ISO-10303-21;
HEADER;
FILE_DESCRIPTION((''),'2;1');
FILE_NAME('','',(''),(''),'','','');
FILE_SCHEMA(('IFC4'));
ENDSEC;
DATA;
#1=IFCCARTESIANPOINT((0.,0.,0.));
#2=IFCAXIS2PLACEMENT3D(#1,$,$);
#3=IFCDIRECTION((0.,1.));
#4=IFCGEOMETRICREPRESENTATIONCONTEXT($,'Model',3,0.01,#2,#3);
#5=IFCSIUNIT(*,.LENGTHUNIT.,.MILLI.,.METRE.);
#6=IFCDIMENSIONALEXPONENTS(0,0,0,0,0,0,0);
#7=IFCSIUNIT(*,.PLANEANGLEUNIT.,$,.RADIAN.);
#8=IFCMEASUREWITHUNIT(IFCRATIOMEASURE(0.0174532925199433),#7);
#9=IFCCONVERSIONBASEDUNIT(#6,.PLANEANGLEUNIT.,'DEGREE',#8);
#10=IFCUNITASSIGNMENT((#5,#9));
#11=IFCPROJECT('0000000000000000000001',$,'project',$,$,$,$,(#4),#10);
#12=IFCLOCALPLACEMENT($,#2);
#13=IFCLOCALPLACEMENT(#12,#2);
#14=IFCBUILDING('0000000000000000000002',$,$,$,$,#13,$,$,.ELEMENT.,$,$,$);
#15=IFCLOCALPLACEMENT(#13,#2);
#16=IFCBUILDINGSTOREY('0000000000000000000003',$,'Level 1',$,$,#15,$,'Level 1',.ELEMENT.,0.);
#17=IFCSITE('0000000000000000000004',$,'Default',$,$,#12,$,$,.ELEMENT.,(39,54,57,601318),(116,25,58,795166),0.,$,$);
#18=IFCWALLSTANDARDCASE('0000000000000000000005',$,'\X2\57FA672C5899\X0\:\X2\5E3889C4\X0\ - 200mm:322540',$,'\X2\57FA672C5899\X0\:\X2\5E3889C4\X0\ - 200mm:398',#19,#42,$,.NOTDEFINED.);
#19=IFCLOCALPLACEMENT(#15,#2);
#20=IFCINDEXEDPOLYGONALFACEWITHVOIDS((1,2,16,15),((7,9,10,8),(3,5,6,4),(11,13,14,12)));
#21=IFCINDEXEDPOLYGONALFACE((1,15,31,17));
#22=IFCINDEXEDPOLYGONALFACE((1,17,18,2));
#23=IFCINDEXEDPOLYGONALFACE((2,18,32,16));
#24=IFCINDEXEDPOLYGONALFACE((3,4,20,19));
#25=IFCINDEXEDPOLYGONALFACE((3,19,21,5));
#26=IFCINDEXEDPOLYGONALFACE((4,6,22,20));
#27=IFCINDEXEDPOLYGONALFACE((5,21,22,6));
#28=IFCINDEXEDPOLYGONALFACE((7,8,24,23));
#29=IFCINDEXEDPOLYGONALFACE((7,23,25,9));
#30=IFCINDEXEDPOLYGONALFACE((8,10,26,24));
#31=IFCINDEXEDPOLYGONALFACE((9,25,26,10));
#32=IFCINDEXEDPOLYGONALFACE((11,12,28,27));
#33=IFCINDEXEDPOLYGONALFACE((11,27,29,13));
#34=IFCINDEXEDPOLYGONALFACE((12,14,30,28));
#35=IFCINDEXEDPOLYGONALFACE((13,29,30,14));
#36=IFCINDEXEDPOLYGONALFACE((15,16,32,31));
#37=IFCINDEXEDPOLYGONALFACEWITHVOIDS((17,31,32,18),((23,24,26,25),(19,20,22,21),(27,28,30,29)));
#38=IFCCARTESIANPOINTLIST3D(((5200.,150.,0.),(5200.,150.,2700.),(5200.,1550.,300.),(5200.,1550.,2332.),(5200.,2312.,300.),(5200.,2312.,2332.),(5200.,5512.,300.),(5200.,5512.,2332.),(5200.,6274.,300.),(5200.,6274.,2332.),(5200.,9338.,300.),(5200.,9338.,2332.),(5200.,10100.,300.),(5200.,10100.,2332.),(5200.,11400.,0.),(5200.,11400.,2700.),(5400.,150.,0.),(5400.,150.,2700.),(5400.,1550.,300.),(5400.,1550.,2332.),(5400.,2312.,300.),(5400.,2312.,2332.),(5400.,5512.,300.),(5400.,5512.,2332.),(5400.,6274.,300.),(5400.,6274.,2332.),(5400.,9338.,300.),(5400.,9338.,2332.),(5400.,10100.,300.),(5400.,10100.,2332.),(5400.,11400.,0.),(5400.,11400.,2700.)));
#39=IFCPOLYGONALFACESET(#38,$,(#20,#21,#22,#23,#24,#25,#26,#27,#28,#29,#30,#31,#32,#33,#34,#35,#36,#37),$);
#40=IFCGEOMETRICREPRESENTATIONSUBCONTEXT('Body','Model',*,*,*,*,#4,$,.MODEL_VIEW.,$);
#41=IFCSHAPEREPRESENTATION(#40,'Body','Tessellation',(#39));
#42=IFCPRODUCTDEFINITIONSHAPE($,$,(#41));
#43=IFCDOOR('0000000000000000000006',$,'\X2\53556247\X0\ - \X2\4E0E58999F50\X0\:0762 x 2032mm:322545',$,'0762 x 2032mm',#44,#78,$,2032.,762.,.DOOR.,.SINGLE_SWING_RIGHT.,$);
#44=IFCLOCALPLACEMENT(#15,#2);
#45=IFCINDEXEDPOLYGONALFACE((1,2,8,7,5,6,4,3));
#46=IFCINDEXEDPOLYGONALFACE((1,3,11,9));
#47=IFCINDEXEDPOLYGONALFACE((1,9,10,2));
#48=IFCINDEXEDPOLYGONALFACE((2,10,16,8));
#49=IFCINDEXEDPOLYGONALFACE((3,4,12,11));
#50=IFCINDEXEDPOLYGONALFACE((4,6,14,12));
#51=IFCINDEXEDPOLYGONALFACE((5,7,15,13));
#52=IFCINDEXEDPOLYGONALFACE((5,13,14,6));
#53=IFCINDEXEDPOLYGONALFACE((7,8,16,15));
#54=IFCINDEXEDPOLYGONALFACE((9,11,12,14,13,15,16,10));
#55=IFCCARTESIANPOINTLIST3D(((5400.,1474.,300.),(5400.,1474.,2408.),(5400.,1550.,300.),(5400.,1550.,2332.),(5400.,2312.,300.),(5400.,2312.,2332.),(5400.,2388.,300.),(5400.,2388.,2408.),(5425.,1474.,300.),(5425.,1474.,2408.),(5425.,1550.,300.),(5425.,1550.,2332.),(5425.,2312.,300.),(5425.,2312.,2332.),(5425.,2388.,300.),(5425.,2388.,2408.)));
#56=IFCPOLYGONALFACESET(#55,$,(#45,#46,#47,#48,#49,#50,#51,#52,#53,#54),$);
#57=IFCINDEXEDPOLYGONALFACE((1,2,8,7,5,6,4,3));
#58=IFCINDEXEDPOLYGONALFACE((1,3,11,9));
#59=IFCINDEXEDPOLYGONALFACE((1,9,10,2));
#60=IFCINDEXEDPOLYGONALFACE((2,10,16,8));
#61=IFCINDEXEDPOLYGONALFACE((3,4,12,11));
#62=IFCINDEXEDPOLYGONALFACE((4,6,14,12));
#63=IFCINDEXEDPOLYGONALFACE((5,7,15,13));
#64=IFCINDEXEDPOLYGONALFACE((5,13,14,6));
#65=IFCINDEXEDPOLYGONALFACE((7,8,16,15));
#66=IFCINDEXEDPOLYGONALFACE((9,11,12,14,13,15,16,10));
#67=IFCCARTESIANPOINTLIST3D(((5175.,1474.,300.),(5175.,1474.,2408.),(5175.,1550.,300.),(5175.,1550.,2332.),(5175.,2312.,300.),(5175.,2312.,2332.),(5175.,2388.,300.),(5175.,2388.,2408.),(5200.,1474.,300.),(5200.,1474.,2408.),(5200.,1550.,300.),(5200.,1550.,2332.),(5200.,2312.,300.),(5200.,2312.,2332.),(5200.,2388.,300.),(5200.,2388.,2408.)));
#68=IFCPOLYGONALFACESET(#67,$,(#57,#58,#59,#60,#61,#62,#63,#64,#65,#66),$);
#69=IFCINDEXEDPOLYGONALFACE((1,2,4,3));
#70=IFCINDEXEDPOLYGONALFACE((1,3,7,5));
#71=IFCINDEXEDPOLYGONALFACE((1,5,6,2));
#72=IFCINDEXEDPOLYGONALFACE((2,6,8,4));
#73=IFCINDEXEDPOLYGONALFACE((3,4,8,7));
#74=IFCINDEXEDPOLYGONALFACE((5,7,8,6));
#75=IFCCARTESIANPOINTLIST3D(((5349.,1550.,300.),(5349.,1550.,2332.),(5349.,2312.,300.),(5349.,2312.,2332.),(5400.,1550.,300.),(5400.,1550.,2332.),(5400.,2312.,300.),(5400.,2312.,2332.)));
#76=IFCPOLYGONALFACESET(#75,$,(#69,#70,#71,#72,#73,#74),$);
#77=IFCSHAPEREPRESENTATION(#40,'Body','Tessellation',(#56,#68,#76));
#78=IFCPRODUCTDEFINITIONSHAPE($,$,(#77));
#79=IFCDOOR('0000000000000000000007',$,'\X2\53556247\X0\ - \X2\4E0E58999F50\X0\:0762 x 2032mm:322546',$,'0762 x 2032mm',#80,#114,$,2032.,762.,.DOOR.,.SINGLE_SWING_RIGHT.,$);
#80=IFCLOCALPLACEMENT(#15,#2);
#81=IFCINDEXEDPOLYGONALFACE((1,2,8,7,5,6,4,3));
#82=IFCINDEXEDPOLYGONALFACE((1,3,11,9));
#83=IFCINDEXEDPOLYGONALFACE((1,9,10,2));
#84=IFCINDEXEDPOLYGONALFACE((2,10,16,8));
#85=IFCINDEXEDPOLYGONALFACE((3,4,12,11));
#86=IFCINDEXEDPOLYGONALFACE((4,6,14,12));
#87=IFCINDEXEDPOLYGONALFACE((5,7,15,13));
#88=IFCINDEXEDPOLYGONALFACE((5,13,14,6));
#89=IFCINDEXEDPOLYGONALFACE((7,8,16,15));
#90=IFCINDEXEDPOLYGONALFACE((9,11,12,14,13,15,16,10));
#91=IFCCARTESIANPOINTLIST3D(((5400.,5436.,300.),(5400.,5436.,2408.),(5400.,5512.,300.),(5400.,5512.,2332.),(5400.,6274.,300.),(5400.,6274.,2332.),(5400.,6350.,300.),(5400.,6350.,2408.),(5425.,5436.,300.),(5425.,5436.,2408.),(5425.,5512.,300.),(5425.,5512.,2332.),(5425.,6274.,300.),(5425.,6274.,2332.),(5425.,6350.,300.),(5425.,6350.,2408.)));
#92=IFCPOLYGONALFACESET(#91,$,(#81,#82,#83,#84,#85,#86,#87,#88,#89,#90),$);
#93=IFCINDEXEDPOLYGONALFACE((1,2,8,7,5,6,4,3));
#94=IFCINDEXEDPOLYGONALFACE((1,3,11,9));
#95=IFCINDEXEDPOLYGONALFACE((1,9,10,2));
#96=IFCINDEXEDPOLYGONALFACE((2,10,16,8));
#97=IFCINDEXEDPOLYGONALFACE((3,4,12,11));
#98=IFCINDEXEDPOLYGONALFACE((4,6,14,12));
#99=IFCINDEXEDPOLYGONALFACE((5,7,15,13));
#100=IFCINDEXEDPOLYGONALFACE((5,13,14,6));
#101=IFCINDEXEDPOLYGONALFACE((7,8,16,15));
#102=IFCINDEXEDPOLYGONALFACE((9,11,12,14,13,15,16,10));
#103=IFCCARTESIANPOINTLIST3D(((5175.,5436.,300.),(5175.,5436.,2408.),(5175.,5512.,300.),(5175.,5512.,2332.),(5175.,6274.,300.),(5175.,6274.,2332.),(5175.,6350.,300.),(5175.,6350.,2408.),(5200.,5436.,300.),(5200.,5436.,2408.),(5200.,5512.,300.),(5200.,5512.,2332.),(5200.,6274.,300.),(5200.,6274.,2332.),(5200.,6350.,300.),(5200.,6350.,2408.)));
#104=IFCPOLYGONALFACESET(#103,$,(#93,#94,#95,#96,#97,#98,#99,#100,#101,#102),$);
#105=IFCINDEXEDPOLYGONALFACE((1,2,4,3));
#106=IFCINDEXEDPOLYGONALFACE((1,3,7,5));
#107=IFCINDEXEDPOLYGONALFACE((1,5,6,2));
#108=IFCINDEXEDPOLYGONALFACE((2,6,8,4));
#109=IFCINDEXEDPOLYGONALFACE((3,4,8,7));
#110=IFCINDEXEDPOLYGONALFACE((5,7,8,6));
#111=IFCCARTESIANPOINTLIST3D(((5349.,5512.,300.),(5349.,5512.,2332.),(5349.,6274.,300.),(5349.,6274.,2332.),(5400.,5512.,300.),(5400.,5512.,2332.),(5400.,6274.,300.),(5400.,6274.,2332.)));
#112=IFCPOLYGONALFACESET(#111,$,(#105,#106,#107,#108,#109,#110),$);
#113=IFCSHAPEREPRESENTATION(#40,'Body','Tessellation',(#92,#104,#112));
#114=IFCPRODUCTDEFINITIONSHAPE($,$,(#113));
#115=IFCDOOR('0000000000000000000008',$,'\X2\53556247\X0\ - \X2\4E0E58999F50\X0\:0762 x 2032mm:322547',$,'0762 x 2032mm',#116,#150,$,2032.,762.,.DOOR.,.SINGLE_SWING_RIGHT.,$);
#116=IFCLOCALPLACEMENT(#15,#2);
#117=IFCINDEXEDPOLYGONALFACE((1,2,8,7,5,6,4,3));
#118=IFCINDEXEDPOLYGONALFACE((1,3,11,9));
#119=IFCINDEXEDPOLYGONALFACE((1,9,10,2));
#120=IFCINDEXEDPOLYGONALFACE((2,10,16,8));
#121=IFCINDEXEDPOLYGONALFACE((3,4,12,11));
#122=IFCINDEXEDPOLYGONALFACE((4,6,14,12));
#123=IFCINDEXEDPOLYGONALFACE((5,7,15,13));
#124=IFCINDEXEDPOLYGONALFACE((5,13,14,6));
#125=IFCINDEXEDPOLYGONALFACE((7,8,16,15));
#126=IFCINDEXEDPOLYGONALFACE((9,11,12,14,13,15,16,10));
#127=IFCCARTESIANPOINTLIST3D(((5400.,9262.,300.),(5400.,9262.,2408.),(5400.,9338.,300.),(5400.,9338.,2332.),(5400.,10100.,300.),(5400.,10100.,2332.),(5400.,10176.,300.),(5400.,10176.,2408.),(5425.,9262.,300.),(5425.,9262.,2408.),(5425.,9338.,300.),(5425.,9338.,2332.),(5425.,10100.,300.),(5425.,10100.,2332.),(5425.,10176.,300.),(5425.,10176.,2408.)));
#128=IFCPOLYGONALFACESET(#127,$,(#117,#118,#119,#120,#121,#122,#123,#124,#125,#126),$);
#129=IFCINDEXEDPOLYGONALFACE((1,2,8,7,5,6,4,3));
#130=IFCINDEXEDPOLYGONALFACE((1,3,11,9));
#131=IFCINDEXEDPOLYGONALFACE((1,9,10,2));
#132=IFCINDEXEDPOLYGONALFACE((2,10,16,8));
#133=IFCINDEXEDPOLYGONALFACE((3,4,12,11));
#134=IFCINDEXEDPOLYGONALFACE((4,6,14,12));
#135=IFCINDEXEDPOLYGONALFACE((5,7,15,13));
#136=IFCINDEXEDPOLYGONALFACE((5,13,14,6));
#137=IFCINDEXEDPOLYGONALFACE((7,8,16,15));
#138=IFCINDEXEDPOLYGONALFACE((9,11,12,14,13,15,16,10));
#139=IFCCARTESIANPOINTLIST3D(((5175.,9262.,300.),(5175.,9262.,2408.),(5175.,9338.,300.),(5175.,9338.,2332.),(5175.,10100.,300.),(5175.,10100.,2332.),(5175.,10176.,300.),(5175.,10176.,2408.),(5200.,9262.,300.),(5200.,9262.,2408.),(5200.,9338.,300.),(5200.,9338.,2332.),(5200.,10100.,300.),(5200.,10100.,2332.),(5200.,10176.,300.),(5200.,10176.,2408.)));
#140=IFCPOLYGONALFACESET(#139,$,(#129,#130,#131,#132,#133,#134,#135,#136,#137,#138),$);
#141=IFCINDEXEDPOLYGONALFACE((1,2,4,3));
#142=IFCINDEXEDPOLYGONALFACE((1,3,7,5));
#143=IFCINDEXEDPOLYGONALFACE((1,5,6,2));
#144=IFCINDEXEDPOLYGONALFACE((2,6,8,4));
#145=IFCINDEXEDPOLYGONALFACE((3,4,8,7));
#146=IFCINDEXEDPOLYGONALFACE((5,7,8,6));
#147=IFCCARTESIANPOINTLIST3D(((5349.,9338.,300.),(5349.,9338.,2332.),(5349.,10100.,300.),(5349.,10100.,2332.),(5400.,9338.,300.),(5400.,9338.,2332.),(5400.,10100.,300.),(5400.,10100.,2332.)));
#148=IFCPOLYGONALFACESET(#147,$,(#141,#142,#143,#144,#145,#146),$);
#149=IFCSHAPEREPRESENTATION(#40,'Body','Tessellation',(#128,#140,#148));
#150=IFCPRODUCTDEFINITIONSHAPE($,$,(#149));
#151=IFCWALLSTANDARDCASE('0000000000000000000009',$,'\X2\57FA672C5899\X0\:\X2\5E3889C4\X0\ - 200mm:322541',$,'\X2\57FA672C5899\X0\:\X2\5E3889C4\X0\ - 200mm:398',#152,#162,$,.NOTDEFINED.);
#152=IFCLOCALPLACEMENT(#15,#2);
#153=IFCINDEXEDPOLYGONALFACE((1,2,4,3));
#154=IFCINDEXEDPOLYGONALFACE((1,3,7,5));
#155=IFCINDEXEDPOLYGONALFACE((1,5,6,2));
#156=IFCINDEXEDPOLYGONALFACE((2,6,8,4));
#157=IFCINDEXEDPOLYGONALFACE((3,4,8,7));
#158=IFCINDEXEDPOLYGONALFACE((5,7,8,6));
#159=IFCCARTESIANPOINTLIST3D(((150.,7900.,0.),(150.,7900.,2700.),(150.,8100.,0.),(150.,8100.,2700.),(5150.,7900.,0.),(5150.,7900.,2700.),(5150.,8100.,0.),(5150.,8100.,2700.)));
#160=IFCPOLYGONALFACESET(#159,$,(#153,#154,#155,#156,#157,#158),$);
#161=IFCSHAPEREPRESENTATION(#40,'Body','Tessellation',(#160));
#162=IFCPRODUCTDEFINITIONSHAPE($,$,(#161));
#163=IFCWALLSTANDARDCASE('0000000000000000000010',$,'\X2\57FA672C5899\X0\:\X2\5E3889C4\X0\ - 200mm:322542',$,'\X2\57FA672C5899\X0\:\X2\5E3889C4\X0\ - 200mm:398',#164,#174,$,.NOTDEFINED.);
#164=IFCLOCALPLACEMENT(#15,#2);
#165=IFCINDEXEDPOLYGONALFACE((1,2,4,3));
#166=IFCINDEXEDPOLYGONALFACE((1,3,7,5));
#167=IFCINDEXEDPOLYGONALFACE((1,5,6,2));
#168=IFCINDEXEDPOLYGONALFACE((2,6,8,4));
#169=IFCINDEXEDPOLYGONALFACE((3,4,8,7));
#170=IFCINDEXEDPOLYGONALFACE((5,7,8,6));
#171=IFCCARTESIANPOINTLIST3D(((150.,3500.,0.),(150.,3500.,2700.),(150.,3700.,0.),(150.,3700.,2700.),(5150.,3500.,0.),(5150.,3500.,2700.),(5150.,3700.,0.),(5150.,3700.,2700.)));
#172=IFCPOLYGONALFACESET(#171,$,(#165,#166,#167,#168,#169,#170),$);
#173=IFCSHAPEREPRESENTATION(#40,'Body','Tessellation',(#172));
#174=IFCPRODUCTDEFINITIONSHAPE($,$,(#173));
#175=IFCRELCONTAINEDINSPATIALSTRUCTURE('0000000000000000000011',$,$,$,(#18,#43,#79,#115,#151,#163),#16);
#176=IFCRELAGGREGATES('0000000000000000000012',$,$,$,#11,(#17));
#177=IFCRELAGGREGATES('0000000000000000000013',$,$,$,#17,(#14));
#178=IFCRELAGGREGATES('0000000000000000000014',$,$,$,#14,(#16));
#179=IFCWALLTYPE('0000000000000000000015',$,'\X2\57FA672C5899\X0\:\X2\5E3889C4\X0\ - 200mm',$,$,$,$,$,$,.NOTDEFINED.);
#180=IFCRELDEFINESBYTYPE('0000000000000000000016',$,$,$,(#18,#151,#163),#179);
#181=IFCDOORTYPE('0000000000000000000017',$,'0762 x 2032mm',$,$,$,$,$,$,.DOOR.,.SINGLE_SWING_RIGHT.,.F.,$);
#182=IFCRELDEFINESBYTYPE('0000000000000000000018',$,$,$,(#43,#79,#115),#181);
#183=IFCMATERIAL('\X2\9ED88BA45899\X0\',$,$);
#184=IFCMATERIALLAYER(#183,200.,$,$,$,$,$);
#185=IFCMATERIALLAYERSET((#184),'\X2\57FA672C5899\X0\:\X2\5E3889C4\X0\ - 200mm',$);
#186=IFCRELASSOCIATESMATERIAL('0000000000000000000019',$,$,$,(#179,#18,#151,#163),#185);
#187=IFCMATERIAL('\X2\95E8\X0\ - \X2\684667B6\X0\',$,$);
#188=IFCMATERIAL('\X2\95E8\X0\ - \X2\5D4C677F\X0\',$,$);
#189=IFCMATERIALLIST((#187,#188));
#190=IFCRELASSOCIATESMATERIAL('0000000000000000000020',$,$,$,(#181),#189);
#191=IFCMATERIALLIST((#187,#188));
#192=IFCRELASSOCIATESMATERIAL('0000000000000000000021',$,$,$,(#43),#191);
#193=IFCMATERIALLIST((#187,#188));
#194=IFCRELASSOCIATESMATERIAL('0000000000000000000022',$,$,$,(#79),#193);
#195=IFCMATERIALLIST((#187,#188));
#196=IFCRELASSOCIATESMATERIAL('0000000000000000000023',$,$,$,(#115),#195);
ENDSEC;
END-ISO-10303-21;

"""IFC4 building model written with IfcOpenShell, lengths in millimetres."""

from ifc_helpers import new_model, entity, si_unit, converted_unit, direction, frame, frame_2d, origin, place, context, subcontext, project, spatial, polyline, rectangle, outline, extrude, clip, bounded_halfspace, source, transform, mapped, material, material_list, layer, layer_set, layer_usage, type_object, type_shapes, element, fill, save


model = new_model("IFC4")

# Units and contexts
model_context_1 = context("Model", 3, precision=0.01, world=origin(), true_north=direction((0.0, 1.0)))
body_context_1 = subcontext(model_context_1, "Body", "Model", "MODEL_VIEW")
ifc_project = project(units=[si_unit("LENGTHUNIT", "METRE", prefix="MILLI"), converted_unit("PLANEANGLEUNIT", "DEGREE", entity("IfcRatioMeasure", 0.0174532925199433), si_unit("PLANEANGLEUNIT", "RADIAN"), dimensions=[0, 0, 0, 0, 0, 0, 0])], contexts=[model_context_1])

# Site, building, storey
site_placement = place(None, origin())
site = spatial("IfcSite", under=ifc_project, at=site_placement, Name="Default", CompositionType="ELEMENT", RefLatitude=(39, 54, 57, 601318), RefLongitude=(116, 25, 58, 795166), RefElevation=0.0)
building_placement = place(site_placement, origin())
building = spatial("IfcBuilding", under=site, at=building_placement, CompositionType="ELEMENT")
storey_placement = place(building_placement, origin())
storey = spatial("IfcBuildingStorey", under=building, at=storey_placement, Name="Level 1", LongName="Level 1", CompositionType="ELEMENT", Elevation=0.0)

# Shared definitions
ifc_material_1 = material(Name="默认墙")
ifc_layer_1 = layer(ifc_material_1, 200.0)
ifc_layer_set_1 = layer_set([ifc_layer_1], Name="基本墙:常规 - 200mm")
wall_type = type_object("IfcWallType", Name="基本墙:常规 - 200mm", PredefinedType="NOTDEFINED", material=ifc_layer_set_1)

# Wall, openings, doors
ifc_layer_usage_1 = layer_usage(ifc_layer_set_1, "AXIS2", "NEGATIVE", 100.0)
wall_1_placement = place(storey_placement, frame((5300.0, 11400.0, 0.0), z_axis=(0.0, 0.0, 1.0), x_axis=(0.0, -1.0, 0.0)))
wall_1 = element("IfcWallStandardCase", 1, at=wall_1_placement, inside=storey, type_object=wall_type, material=ifc_layer_usage_1, Name="基本墙:常规 - 200mm:322540", ObjectType="基本墙:常规 - 200mm:398", PredefinedType="NOTDEFINED", context=body_context_1, shape_type="Clipping", body=[
    clip(extrude(rectangle(XDim=11250.0, YDim=200.0, at=frame_2d((5625.0, 0.0), x_axis=(-1.0, 0.0))), origin(), (0.0, 0.0, 1.0), 2700.0), bounded_halfspace(frame((0.0, -100.0, 2700.0), z_axis=(0.0, 0.0, -1.0), x_axis=(-1.0, 0.0, 0.0)), True, frame((0.0, -100.0, 2700.0)), polyline([(0.0, 0.0), (11250.0, 0.0), (11250.0, 200.0), (0.0, 200.0), (0.0, 0.0)]))),
])
opening_1_placement = place(wall_1_placement, frame((9088.0, -100.0, 300.0)))
opening_1 = element("IfcOpeningElement", 2, at=opening_1_placement, cuts=wall_1, ObjectType="Opening", PredefinedType="OPENING", context=body_context_1, shape_type="SweptSolid", body=[
    extrude(rectangle(XDim=762.0, YDim=2032.0, at=frame_2d((1016.0, 381.0), x_axis=(0.0, 1.0))), frame((0.0, 0.0, 0.0), z_axis=(0.0, 1.0, 0.0), x_axis=(0.0, 0.0, 1.0)), (0.0, 0.0, 1.0), 200.0),
])
opening_2_placement = place(wall_1_placement, frame((5126.0, -100.0, 300.0)))
opening_2 = element("IfcOpeningElement", 3, at=opening_2_placement, cuts=wall_1, ObjectType="Opening", PredefinedType="OPENING", context=body_context_1, shape_type="SweptSolid", body=[
    extrude(rectangle(XDim=762.0, YDim=2032.0, at=frame_2d((1016.0, 381.0), x_axis=(0.0, 1.0))), frame((0.0, 0.0, 0.0), z_axis=(0.0, 1.0, 0.0), x_axis=(0.0, 0.0, 1.0)), (0.0, 0.0, 1.0), 200.0),
])
opening_3_placement = place(wall_1_placement, frame((1300.0, -100.0, 300.0)))
opening_3 = element("IfcOpeningElement", 4, at=opening_3_placement, cuts=wall_1, ObjectType="Opening", PredefinedType="OPENING", context=body_context_1, shape_type="SweptSolid", body=[
    extrude(rectangle(XDim=762.0, YDim=2032.0, at=frame_2d((1016.0, 381.0), x_axis=(0.0, 1.0))), frame((0.0, 0.0, 0.0), z_axis=(0.0, 1.0, 0.0), x_axis=(0.0, 0.0, 1.0)), (0.0, 0.0, 1.0), 200.0),
])
ifc_material_2 = material(Name="门 - 框架")
ifc_material_3 = material(Name="门 - 嵌板")
ifc_material_list_1 = material_list([ifc_material_2, ifc_material_3])
ifc_material_list_2 = material_list([ifc_material_2, ifc_material_3])
door_type = type_object("IfcDoorType", Name="0762 x 2032mm", OperationType="SINGLE_SWING_RIGHT", ParameterTakesPrecedence=False, PredefinedType="DOOR", material=ifc_material_list_2)
shared_shape_1 = source(origin(), body_context_1, "Body", "SweptSolid", [
    extrude(outline(polyline([(-457.0, -1073.0), (457.0, -1073.0), (457.0, 1035.0), (381.0, 1035.0), (381.0, -997.0), (-381.0, -997.0), (-381.0, 1035.0), (-457.0, 1035.0), (-457.0, -1073.0)])), frame((381.0, 200.0, 1035.0), z_axis=(0.0, 1.0, 0.0), x_axis=(1.0, 0.0, 0.0)), (0.0, 0.0, 1.0), 25.0),
    extrude(outline(polyline([(-1073.0, -457.0), (1035.0, -457.0), (1035.0, -381.0), (-997.0, -381.0), (-997.0, 381.0), (1035.0, 381.0), (1035.0, 457.0), (-1073.0, 457.0), (-1073.0, -457.0)])), frame((381.0, -25.0, 1035.0), z_axis=(0.0, 1.0, 0.0), x_axis=(0.0, 0.0, -1.0)), (0.0, 0.0, 1.0), 25.0),
    extrude(rectangle(XDim=51.0, YDim=762.0, at=frame_2d((0.0, 0.0), x_axis=(1.0, 0.0))), frame((381.0, 174.5, 0.0), z_axis=(0.0, 0.0, 1.0), x_axis=(0.0, 1.0, 0.0)), (0.0, 0.0, 1.0), 2032.0),
])
type_shapes(door_type, [shared_shape_1])
door_1_placement = place(opening_1_placement, origin())
door_1 = element("IfcDoor", 5, at=door_1_placement, inside=storey, type_object=door_type, material=ifc_material_list_1, Name="单扇 - 与墙齐:0762 x 2032mm:322545", ObjectType="0762 x 2032mm", OperationType="SINGLE_SWING_RIGHT", OverallHeight=2032.0, OverallWidth=762.0, PredefinedType="DOOR", context=body_context_1, shape_type="MappedRepresentation", body=[
    mapped(shared_shape_1, transform((0.0, 0.0, 0.0), scale=1.0)),
])
fill(opening_1, door_1)
ifc_material_list_3 = material_list([ifc_material_2, ifc_material_3])
door_2_placement = place(opening_2_placement, origin())
door_2 = element("IfcDoor", 6, at=door_2_placement, inside=storey, type_object=door_type, material=ifc_material_list_3, Name="单扇 - 与墙齐:0762 x 2032mm:322546", ObjectType="0762 x 2032mm", OperationType="SINGLE_SWING_RIGHT", OverallHeight=2032.0, OverallWidth=762.0, PredefinedType="DOOR", context=body_context_1, shape_type="MappedRepresentation", body=[
    mapped(shared_shape_1, transform((0.0, 0.0, 0.0), scale=1.0)),
])
fill(opening_2, door_2)
ifc_material_list_4 = material_list([ifc_material_2, ifc_material_3])
door_3_placement = place(opening_3_placement, origin())
door_3 = element("IfcDoor", 7, at=door_3_placement, inside=storey, type_object=door_type, material=ifc_material_list_4, Name="单扇 - 与墙齐:0762 x 2032mm:322547", ObjectType="0762 x 2032mm", OperationType="SINGLE_SWING_RIGHT", OverallHeight=2032.0, OverallWidth=762.0, PredefinedType="DOOR", context=body_context_1, shape_type="MappedRepresentation", body=[
    mapped(shared_shape_1, transform((0.0, 0.0, 0.0), scale=1.0)),
])
fill(opening_3, door_3)

# Walls
ifc_layer_usage_2 = layer_usage(ifc_layer_set_1, "AXIS2", "NEGATIVE", 100.0)
wall_2_placement = place(storey_placement, frame((150.0, 8000.0, 0.0)))
element("IfcWallStandardCase", 8, at=wall_2_placement, inside=storey, type_object=wall_type, material=ifc_layer_usage_2, Name="基本墙:常规 - 200mm:322541", ObjectType="基本墙:常规 - 200mm:398", PredefinedType="NOTDEFINED", context=body_context_1, shape_type="Clipping", body=[
    clip(extrude(rectangle(XDim=5000.0, YDim=200.0, at=frame_2d((2500.0, 0.0), x_axis=(-1.0, 0.0))), origin(), (0.0, 0.0, 1.0), 2700.0), bounded_halfspace(frame((0.0, -100.0, 2700.0), z_axis=(0.0, 0.0, -1.0), x_axis=(0.0, 1.0, 0.0)), True, frame((0.0, -100.0, 2700.0)), polyline([(0.0, 0.0), (5000.0, 0.0), (5000.0, 200.0), (0.0, 200.0), (0.0, 0.0)]))),
])
ifc_layer_usage_3 = layer_usage(ifc_layer_set_1, "AXIS2", "NEGATIVE", 100.0)
wall_3_placement = place(storey_placement, frame((150.0, 3600.0, 0.0)))
element("IfcWallStandardCase", 9, at=wall_3_placement, inside=storey, type_object=wall_type, material=ifc_layer_usage_3, Name="基本墙:常规 - 200mm:322542", ObjectType="基本墙:常规 - 200mm:398", PredefinedType="NOTDEFINED", context=body_context_1, shape_type="Clipping", body=[
    clip(extrude(rectangle(XDim=5000.0, YDim=200.0, at=frame_2d((2500.0, 0.0), x_axis=(-1.0, 0.0))), origin(), (0.0, 0.0, 1.0), 2700.0), bounded_halfspace(frame((0.0, -100.0, 2700.0), z_axis=(0.0, 0.0, -1.0), x_axis=(0.0, 1.0, 0.0)), True, frame((0.0, -100.0, 2700.0)), polyline([(0.0, 0.0), (5000.0, 0.0), (5000.0, 200.0), (0.0, 200.0), (0.0, 0.0)]))),
])

save(model, "model.ifc")
